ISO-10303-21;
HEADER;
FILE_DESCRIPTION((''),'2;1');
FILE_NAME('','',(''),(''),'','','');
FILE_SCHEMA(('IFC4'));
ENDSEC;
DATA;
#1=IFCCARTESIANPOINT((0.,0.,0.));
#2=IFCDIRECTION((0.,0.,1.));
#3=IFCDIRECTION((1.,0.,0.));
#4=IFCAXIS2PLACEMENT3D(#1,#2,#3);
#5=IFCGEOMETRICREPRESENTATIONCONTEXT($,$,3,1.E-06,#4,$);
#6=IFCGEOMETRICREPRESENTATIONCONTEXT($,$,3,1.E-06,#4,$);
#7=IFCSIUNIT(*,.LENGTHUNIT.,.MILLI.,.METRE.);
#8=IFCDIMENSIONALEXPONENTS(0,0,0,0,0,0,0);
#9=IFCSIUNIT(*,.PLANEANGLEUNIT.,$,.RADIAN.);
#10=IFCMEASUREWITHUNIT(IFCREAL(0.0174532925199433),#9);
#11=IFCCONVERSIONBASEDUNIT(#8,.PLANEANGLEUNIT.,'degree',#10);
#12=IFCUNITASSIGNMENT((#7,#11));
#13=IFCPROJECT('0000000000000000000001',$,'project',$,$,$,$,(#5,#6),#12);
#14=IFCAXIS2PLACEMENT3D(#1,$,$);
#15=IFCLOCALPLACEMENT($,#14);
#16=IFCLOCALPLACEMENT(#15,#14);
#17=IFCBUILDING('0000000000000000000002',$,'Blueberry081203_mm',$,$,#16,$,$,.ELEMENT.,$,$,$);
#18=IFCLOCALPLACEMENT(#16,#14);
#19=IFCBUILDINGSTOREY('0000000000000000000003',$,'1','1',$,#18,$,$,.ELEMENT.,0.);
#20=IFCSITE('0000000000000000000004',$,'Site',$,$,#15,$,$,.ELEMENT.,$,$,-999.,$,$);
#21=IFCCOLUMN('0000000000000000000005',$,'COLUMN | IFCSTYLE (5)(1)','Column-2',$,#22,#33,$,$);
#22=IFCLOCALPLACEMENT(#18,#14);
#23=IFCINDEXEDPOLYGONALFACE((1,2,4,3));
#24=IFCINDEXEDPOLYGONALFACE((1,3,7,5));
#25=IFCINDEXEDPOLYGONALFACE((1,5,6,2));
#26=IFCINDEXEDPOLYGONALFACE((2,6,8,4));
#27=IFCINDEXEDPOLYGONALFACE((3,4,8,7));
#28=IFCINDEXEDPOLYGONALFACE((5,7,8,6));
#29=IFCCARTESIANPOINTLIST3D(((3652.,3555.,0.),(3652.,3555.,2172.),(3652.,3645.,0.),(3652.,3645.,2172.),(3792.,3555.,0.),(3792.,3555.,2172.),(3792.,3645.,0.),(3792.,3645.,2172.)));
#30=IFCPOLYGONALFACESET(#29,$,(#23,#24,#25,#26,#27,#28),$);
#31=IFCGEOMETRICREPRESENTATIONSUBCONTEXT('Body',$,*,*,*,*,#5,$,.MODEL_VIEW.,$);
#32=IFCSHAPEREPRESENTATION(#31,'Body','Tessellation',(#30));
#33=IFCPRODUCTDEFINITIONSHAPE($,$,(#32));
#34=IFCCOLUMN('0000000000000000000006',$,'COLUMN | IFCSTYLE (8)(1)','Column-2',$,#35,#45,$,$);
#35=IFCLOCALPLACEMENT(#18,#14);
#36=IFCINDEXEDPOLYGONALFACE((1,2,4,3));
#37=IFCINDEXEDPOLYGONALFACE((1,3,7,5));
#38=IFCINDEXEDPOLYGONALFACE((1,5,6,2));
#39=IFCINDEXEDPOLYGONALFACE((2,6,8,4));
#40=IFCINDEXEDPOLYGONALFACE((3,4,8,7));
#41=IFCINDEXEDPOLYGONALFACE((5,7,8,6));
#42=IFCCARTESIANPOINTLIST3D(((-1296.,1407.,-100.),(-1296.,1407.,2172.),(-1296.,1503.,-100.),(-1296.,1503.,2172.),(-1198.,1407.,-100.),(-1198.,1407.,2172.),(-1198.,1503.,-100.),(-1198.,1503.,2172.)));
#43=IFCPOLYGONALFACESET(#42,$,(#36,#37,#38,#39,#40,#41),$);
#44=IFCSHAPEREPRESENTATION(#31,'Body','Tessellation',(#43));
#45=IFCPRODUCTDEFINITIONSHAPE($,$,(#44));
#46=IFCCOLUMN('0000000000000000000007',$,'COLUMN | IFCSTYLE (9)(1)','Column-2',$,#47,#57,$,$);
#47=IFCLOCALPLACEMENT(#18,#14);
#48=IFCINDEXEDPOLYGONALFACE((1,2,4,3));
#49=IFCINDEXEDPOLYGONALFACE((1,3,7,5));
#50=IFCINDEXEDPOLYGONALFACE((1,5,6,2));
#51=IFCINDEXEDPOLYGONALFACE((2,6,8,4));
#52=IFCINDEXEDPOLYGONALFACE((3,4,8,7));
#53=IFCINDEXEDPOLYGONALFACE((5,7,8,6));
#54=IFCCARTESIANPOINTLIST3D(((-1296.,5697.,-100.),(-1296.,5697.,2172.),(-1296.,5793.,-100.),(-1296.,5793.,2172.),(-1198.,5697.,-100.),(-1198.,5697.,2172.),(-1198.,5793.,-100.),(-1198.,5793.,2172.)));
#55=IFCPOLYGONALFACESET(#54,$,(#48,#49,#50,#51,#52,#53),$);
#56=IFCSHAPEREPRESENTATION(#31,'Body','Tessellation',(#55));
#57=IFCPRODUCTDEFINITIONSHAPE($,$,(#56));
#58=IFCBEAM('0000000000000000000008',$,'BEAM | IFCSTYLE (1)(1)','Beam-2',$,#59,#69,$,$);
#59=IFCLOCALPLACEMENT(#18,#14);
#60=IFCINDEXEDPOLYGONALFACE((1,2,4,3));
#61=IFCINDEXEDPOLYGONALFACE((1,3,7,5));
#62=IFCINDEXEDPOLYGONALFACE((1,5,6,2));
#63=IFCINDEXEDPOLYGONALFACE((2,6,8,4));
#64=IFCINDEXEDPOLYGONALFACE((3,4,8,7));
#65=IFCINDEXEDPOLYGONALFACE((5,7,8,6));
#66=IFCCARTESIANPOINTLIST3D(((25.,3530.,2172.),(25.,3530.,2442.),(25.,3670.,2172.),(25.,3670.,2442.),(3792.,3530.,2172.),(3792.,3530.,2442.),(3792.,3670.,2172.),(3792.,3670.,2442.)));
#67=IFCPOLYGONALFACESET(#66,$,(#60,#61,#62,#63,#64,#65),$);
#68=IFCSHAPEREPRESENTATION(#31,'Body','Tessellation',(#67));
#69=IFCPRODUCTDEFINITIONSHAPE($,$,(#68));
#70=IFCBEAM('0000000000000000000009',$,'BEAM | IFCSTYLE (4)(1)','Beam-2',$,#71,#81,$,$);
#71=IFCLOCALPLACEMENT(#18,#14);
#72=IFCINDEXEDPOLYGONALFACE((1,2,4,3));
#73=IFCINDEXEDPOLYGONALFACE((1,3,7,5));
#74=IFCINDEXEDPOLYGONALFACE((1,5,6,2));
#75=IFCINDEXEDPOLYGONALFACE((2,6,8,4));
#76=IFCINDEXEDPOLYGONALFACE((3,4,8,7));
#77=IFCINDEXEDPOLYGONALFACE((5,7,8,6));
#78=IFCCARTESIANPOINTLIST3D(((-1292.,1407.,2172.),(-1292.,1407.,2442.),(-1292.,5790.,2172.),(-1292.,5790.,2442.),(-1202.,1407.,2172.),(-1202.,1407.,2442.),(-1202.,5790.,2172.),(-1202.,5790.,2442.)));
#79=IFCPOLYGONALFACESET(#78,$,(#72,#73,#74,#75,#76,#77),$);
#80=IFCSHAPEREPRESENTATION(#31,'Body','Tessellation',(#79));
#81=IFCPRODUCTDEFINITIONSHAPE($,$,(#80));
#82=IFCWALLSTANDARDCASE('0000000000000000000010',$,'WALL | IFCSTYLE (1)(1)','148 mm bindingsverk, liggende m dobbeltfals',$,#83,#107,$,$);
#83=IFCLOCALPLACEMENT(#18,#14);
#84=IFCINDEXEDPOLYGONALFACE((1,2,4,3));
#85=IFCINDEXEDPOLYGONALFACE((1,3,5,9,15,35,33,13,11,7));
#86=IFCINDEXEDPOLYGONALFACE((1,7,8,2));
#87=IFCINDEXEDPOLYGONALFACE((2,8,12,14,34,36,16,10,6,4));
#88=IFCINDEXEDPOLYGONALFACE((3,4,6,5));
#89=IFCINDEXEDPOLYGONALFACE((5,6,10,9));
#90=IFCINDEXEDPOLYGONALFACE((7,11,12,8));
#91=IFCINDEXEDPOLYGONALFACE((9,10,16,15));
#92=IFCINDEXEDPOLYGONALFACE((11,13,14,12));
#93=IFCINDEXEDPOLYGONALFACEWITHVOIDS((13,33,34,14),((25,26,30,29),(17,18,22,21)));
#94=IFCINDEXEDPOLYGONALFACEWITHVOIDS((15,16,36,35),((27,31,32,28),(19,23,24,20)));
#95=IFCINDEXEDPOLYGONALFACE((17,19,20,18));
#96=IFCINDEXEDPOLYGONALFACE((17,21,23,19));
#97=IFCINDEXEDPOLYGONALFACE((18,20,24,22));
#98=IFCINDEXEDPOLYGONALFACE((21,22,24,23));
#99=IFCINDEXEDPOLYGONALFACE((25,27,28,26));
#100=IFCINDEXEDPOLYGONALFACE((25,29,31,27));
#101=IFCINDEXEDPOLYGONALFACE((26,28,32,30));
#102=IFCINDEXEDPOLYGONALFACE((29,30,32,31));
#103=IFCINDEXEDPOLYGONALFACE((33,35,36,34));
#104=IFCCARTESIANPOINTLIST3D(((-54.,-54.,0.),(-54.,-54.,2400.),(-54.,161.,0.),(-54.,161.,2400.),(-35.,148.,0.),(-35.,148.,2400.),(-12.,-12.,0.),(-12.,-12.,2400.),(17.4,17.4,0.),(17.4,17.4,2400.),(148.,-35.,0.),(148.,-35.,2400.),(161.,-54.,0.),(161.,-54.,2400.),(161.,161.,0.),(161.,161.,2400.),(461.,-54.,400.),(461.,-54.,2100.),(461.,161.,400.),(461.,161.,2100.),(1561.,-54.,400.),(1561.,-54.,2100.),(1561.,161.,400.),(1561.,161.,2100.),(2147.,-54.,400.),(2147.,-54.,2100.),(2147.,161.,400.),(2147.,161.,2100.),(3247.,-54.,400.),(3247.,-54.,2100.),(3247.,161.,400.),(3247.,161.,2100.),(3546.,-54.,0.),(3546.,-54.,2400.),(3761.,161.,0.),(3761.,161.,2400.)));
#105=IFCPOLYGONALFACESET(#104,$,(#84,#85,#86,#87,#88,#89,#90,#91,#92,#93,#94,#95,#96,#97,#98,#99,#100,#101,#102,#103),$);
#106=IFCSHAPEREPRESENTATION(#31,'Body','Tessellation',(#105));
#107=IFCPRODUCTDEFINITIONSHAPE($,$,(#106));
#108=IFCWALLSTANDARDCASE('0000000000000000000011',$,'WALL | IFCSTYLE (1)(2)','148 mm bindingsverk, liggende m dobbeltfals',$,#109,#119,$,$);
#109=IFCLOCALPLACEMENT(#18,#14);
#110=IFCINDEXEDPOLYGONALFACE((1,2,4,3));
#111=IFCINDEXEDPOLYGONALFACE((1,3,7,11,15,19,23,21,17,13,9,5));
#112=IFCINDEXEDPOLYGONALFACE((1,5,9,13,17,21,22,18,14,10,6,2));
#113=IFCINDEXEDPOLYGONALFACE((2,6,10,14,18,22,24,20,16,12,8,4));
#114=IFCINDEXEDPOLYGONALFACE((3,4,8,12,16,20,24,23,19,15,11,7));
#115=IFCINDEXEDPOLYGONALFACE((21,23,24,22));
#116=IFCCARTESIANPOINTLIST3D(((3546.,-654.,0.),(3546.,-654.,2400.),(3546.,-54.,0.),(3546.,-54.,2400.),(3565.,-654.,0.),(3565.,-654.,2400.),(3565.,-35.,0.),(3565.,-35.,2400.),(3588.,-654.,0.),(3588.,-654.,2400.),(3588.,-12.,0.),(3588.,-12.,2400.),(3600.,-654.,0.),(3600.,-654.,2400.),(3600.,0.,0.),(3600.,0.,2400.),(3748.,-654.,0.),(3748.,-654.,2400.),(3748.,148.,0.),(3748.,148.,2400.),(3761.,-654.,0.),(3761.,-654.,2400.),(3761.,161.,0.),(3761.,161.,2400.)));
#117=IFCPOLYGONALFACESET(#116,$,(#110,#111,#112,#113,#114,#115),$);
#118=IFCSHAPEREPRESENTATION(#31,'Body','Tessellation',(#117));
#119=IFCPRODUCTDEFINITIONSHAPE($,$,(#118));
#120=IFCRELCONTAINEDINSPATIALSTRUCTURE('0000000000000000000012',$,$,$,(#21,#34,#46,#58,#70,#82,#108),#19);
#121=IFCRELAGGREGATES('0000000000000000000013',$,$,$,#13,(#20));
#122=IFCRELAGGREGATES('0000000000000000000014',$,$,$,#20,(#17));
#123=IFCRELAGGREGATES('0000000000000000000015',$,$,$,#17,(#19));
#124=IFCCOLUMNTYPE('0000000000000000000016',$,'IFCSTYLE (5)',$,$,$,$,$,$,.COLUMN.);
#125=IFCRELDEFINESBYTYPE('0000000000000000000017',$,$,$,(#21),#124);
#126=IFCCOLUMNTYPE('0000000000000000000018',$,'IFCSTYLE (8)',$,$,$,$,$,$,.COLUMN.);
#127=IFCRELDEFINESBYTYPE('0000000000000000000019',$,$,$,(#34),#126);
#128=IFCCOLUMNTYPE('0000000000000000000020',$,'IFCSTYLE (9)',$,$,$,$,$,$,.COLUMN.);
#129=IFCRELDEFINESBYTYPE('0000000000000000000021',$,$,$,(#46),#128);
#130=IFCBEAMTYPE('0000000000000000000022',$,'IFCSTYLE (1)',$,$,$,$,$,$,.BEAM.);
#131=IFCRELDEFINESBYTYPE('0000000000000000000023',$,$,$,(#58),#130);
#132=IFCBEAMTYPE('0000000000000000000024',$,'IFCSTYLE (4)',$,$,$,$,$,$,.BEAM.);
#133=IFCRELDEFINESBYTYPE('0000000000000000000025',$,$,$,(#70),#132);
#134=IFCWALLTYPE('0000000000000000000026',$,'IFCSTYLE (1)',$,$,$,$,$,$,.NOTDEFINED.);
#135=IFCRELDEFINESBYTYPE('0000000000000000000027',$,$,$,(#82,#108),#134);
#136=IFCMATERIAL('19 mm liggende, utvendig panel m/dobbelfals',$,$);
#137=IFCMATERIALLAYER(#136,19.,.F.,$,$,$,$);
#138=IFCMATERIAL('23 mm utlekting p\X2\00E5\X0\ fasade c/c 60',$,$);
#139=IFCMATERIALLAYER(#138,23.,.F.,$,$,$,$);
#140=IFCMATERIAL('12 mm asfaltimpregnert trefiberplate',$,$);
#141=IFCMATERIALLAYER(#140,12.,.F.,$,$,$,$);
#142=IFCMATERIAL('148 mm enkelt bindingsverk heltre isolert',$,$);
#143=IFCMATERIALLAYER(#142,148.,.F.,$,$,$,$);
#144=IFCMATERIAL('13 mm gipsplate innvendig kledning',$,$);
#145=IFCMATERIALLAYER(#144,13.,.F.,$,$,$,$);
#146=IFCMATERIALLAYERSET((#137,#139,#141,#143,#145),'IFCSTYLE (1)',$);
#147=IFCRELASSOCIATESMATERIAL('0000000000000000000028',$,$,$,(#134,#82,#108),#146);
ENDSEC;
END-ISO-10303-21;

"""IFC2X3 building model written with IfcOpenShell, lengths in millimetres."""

from ifc_helpers import new_model, entity, si_unit, converted_unit, frame, frame_2d, origin, origin_with_axes, origin_2d_with_axis, place, context, subcontext, project, spatial, polyline, segment, composite_curve, rectangle, outline, extrude, source, transform, mapped, material, layer, layer_set, layer_usage, type_object, element, save


model = new_model("IFC2X3")

# Units and contexts
context_of_model_1 = context(None, 3, precision=1e-06, world=origin_with_axes())
context_of_model_2 = context(None, 3, precision=1e-06, world=origin_with_axes())
body_context = subcontext(context_of_model_1, "Body", None, "MODEL_VIEW")
ifc_project = project(units=[si_unit("LENGTHUNIT", "METRE", prefix="MILLI"), converted_unit("PLANEANGLEUNIT", "degree", entity("IfcReal", 0.0174532925199433), si_unit("PLANEANGLEUNIT", "RADIAN"), dimensions=[0, 0, 0, 0, 0, 0, 0])], contexts=[context_of_model_1, context_of_model_2])

# Site, building, storey
site_placement = place(None, origin())
site = spatial("IfcSite", under=ifc_project, at=site_placement, Name="Site", CompositionType="ELEMENT", RefElevation=-999.0)
building_placement = place(site_placement, origin())
building = spatial("IfcBuilding", under=site, at=building_placement, Name="Blueberry081203_mm", CompositionType="ELEMENT")
storey_placement = place(building_placement, origin())
storey = spatial("IfcBuildingStorey", under=building, at=storey_placement, Name="1", Description="1", CompositionType="ELEMENT", Elevation=0.0)

# Columns
column_type_1 = type_object("IfcColumnType", Name="IFCSTYLE (5)", PredefinedType="COLUMN")
shared_shape_1 = source(origin(), body_context, "Body", "SweptSolid", [
    extrude(rectangle(XDim=140.0, YDim=90.0, at=frame_2d((70.0, 45.0), x_axis=(1.0, 0.0))), frame((0.0, 0.0, 0.0), z_axis=(1.0, 0.0, 0.0), x_axis=(0.0, 1.0, 0.0)), (0.0, 0.0, 1.0), 1.0),
])
column_1_placement = place(storey_placement, frame((3652.0, 3555.0, 0.0), z_axis=(0.0, 1.0, 0.0), x_axis=(0.0, 0.0, 1.0)))
element("IfcColumn", 1, at=column_1_placement, inside=storey, type_object=column_type_1, Name="COLUMN | IFCSTYLE (5)(1)", Description="Column-2", context=body_context, shape_type="MappedRepresentation", held_by="IfcProductRepresentation", body=[
    mapped(shared_shape_1, transform((0.0, 0.0, 0.0), x_axis=(1.0, 0.0, 0.0), y_axis=(0.0, 1.0, 0.0), z_axis=(0.0, 0.0, 1.0), scale=2171.999931, scale2=1.0, scale3=1.0, uniform=False)),
])
column_type_2 = type_object("IfcColumnType", Name="IFCSTYLE (8)", PredefinedType="COLUMN")
shared_shape_2 = source(origin(), body_context, "Body", "SweptSolid", [
    extrude(rectangle(XDim=96.0, YDim=98.0, at=frame_2d((48.0, 49.0), x_axis=(1.0, 0.0))), frame((0.0, 0.0, 0.0), z_axis=(1.0, 0.0, 0.0), x_axis=(0.0, 1.0, 0.0)), (0.0, 0.0, 1.0), 1.0),
])
column_2_placement = place(storey_placement, frame((-1198.0, 1407.0, -100.0), z_axis=(-1.0, 0.0, 0.0), x_axis=(0.0, 0.0, 1.0)))
element("IfcColumn", 2, at=column_2_placement, inside=storey, type_object=column_type_2, Name="COLUMN | IFCSTYLE (8)(1)", Description="Column-2", context=body_context, shape_type="MappedRepresentation", held_by="IfcProductRepresentation", body=[
    mapped(shared_shape_2, transform((0.0, 0.0, 0.0), x_axis=(1.0, 0.0, 0.0), y_axis=(0.0, 1.0, 0.0), z_axis=(0.0, 0.0, 1.0), scale=2272.000074, scale2=1.0, scale3=1.0, uniform=False)),
])
column_type_3 = type_object("IfcColumnType", Name="IFCSTYLE (9)", PredefinedType="COLUMN")
shared_shape_3 = source(origin(), body_context, "Body", "SweptSolid", [
    extrude(rectangle(XDim=96.0, YDim=98.0, at=frame_2d((48.0, 49.0), x_axis=(1.0, 0.0))), frame((0.0, 0.0, 0.0), z_axis=(1.0, 0.0, 0.0), x_axis=(0.0, 1.0, 0.0)), (0.0, 0.0, 1.0), 1.0),
])
column_3_placement = place(storey_placement, frame((-1198.0, 5697.0, -100.0), z_axis=(-1.0, 0.0, 0.0), x_axis=(0.0, 0.0, 1.0)))
element("IfcColumn", 3, at=column_3_placement, inside=storey, type_object=column_type_3, Name="COLUMN | IFCSTYLE (9)(1)", Description="Column-2", context=body_context, shape_type="MappedRepresentation", held_by="IfcProductRepresentation", body=[
    mapped(shared_shape_3, transform((0.0, 0.0, 0.0), x_axis=(1.0, 0.0, 0.0), y_axis=(0.0, 1.0, 0.0), z_axis=(0.0, 0.0, 1.0), scale=2272.000074, scale2=1.0, scale3=1.0, uniform=False)),
])

# Beams
beam_type_1 = type_object("IfcBeamType", Name="IFCSTYLE (1)", PredefinedType="BEAM")
shared_shape_4 = source(origin(), body_context, "Body", "SweptSolid", [
    extrude(rectangle(XDim=140.0, YDim=270.0, at=frame_2d((70.0, 135.0), x_axis=(1.0, 0.0))), frame((0.0, 0.0, 0.0), z_axis=(1.0, 0.0, 0.0), x_axis=(0.0, 1.0, 0.0)), (0.0, 0.0, 1.0), 1.0),
])
beam_1_placement = place(storey_placement, frame((25.0, 3530.0, 2172.0)))
element("IfcBeam", 4, at=beam_1_placement, inside=storey, type_object=beam_type_1, Name="BEAM | IFCSTYLE (1)(1)", Description="Beam-2", context=body_context, shape_type="MappedRepresentation", held_by="IfcProductRepresentation", body=[
    mapped(shared_shape_4, transform((0.0, 0.0, 0.0), x_axis=(1.0, 0.0, 0.0), y_axis=(0.0, 1.0, 0.0), z_axis=(0.0, 0.0, 1.0), scale=3766.99996, scale2=1.0, scale3=1.0, uniform=False)),
])
beam_type_2 = type_object("IfcBeamType", Name="IFCSTYLE (4)", PredefinedType="BEAM")
shared_shape_5 = source(origin(), body_context, "Body", "SweptSolid", [
    extrude(rectangle(XDim=90.0, YDim=270.0, at=frame_2d((45.0, 135.0), x_axis=(1.0, 0.0))), frame((0.0, 0.0, 0.0), z_axis=(1.0, 0.0, 0.0), x_axis=(0.0, 1.0, 0.0)), (0.0, 0.0, 1.0), 1.0),
])
beam_2_placement = place(storey_placement, frame((-1292.0, 5790.0, 2172.0), z_axis=(0.0, 0.0, 1.0), x_axis=(0.0, -1.0, 0.0)))
element("IfcBeam", 5, at=beam_2_placement, inside=storey, type_object=beam_type_2, Name="BEAM | IFCSTYLE (4)(1)", Description="Beam-2", context=body_context, shape_type="MappedRepresentation", held_by="IfcProductRepresentation", body=[
    mapped(shared_shape_5, transform((0.0, 0.0, 0.0), x_axis=(1.0, 0.0, 0.0), y_axis=(0.0, 1.0, 0.0), z_axis=(0.0, 0.0, 1.0), scale=4382.989407, scale2=1.0, scale3=1.0, uniform=False)),
])

# Wall, openings
ifc_material_1 = material(Name="19 mm liggende, utvendig panel m/dobbelfals")
ifc_layer_1 = layer(ifc_material_1, 19.0, ventilated=False)
ifc_material_2 = material(Name="23 mm utlekting på fasade c/c 60")
ifc_layer_2 = layer(ifc_material_2, 23.0, ventilated=False)
ifc_material_3 = material(Name="12 mm asfaltimpregnert trefiberplate")
ifc_layer_3 = layer(ifc_material_3, 12.0, ventilated=False)
ifc_material_4 = material(Name="148 mm enkelt bindingsverk heltre isolert")
ifc_layer_4 = layer(ifc_material_4, 148.0, ventilated=False)
ifc_material_5 = material(Name="13 mm gipsplate innvendig kledning")
ifc_layer_5 = layer(ifc_material_5, 13.0, ventilated=False)
ifc_layer_set_1 = layer_set([ifc_layer_1, ifc_layer_2, ifc_layer_3, ifc_layer_4, ifc_layer_5], Name="IFCSTYLE (1)")
ifc_layer_usage_1 = layer_usage(ifc_layer_set_1, "AXIS2", "POSITIVE", 0.0)
wall_type_1 = type_object("IfcWallType", Name="IFCSTYLE (1)", PredefinedType="NOTDEFINED", material=ifc_layer_set_1)
wall_1_placement = place(storey_placement, frame((-54.0, -54.0, 0.0)))
wall_1 = element("IfcWallStandardCase", 6, at=wall_1_placement, inside=storey, type_object=wall_type_1, material=ifc_layer_usage_1, Name="WALL | IFCSTYLE (1)(1)", Description="148 mm bindingsverk, liggende m dobbeltfals", context=body_context, shape_type="SweptSolid", held_by="IfcProductRepresentation", body=[
    extrude(outline(composite_curve([segment(polyline([(0.0, 19.0), (0.0, 0.0)]), True, "CONTINUOUS"), segment(polyline([(0.0, 0.0), (0.0, 0.0)]), True, "CONTINUOUS"), segment(polyline([(0.0, 0.0), (19.0, 19.0)]), True, "CONTINUOUS"), segment(polyline([(19.0, 19.0), (42.0, 42.0)]), True, "CONTINUOUS"), segment(polyline([(42.0, 42.0), (202.0, 19.0)]), True, "CONTINUOUS"), segment(polyline([(202.0, 19.0), (215.0, 0.0)]), True, "CONTINUOUS"), segment(polyline([(215.0, 0.0), (3600.0, 0.0)]), True, "CONTINUOUS"), segment(polyline([(3600.0, 0.0), (3619.0, 19.0)]), True, "CONTINUOUS"), segment(polyline([(3619.0, 19.0), (3642.0, 42.0)]), True, "CONTINUOUS"), segment(polyline([(3642.0, 42.0), (3654.0, 54.0)]), True, "CONTINUOUS"), segment(polyline([(3654.0, 54.0), (3802.0, 202.0)]), True, "CONTINUOUS"), segment(polyline([(3802.0, 202.0), (3815.0, 215.0)]), True, "CONTINUOUS"), segment(polyline([(3815.0, 215.0), (215.0, 215.0)]), True, "CONTINUOUS"), segment(polyline([(215.0, 215.0), (202.0, 202.0)]), True, "CONTINUOUS"), segment(polyline([(202.0, 202.0), (71.4, 71.4)]), True, "CONTINUOUS"), segment(polyline([(71.4, 71.4), (19.0, 202.0)]), True, "CONTINUOUS"), segment(polyline([(19.0, 202.0), (0.0, 215.0)]), True, "CONTINUOUS"), segment(polyline([(0.0, 215.0), (0.0, 215.0)]), True, "CONTINUOUS"), segment(polyline([(0.0, 215.0), (0.0, 202.0)]), True, "CONTINUOUS"), segment(polyline([(0.0, 202.0), (0.0, 54.0)]), True, "CONTINUOUS"), segment(polyline([(0.0, 54.0), (0.0, 42.0)]), True, "CONTINUOUS"), segment(polyline([(0.0, 42.0), (0.0, 19.0)]), True, "CONTINUOUS")], self_intersect=False)), origin(), (0.0, 0.0, 1.0), 2400.0),
])
opening_1_placement = place(wall_1_placement, frame((2201.0, 107.5, 400.0)))
element("IfcOpeningElement", 7, at=opening_1_placement, cuts=wall_1, context=body_context, shape_type="SweptSolid", held_by="IfcProductRepresentation", body=[
    extrude(rectangle(XDim=1100.0, YDim=1700.0, at=origin_2d_with_axis()), frame((550.0, 107.5, 850.0), z_axis=(0.0, -1.0, 0.0), x_axis=(1.0, 0.0, 0.0)), (0.0, 0.0, 1.0), 215.0),
])
opening_2_placement = place(wall_1_placement, frame((515.0, 107.5, 400.0)))
element("IfcOpeningElement", 8, at=opening_2_placement, cuts=wall_1, context=body_context, shape_type="SweptSolid", held_by="IfcProductRepresentation", body=[
    extrude(rectangle(XDim=1100.0, YDim=1700.0, at=origin_2d_with_axis()), frame((550.0, 107.5, 850.0), z_axis=(0.0, -1.0, 0.0), x_axis=(1.0, 0.0, 0.0)), (0.0, 0.0, 1.0), 215.0),
])

# Wall
ifc_layer_usage_2 = layer_usage(ifc_layer_set_1, "AXIS2", "POSITIVE", 0.0)
wall_2_placement = place(storey_placement, frame((3546.0, -54.0, 0.0), z_axis=(0.0, 0.0, 1.0), x_axis=(0.0, -1.0, 0.0)))
element("IfcWallStandardCase", 9, at=wall_2_placement, inside=storey, type_object=wall_type_1, material=ifc_layer_usage_2, Name="WALL | IFCSTYLE (1)(2)", Description="148 mm bindingsverk, liggende m dobbeltfals", context=body_context, shape_type="SweptSolid", held_by="IfcProductRepresentation", body=[
    extrude(outline(composite_curve([segment(polyline([(-19.0, 19.0), (0.0, 0.0)]), True, "CONTINUOUS"), segment(polyline([(0.0, 0.0), (600.0, 0.0)]), True, "CONTINUOUS"), segment(polyline([(600.0, 0.0), (600.0, 19.0)]), True, "CONTINUOUS"), segment(polyline([(600.0, 19.0), (600.0, 42.0)]), True, "CONTINUOUS"), segment(polyline([(600.0, 42.0), (600.0, 54.0)]), True, "CONTINUOUS"), segment(polyline([(600.0, 54.0), (600.0, 202.0)]), True, "CONTINUOUS"), segment(polyline([(600.0, 202.0), (600.0, 215.0)]), True, "CONTINUOUS"), segment(polyline([(600.0, 215.0), (-215.0, 215.0)]), True, "CONTINUOUS"), segment(polyline([(-215.0, 215.0), (-202.0, 202.0)]), True, "CONTINUOUS"), segment(polyline([(-202.0, 202.0), (-54.0, 54.0)]), True, "CONTINUOUS"), segment(polyline([(-54.0, 54.0), (-42.0, 42.0)]), True, "CONTINUOUS"), segment(polyline([(-42.0, 42.0), (-19.0, 19.0)]), True, "CONTINUOUS")], self_intersect=False)), origin(), (0.0, 0.0, 1.0), 2400.0),
])

save(model, "model.ifc")
